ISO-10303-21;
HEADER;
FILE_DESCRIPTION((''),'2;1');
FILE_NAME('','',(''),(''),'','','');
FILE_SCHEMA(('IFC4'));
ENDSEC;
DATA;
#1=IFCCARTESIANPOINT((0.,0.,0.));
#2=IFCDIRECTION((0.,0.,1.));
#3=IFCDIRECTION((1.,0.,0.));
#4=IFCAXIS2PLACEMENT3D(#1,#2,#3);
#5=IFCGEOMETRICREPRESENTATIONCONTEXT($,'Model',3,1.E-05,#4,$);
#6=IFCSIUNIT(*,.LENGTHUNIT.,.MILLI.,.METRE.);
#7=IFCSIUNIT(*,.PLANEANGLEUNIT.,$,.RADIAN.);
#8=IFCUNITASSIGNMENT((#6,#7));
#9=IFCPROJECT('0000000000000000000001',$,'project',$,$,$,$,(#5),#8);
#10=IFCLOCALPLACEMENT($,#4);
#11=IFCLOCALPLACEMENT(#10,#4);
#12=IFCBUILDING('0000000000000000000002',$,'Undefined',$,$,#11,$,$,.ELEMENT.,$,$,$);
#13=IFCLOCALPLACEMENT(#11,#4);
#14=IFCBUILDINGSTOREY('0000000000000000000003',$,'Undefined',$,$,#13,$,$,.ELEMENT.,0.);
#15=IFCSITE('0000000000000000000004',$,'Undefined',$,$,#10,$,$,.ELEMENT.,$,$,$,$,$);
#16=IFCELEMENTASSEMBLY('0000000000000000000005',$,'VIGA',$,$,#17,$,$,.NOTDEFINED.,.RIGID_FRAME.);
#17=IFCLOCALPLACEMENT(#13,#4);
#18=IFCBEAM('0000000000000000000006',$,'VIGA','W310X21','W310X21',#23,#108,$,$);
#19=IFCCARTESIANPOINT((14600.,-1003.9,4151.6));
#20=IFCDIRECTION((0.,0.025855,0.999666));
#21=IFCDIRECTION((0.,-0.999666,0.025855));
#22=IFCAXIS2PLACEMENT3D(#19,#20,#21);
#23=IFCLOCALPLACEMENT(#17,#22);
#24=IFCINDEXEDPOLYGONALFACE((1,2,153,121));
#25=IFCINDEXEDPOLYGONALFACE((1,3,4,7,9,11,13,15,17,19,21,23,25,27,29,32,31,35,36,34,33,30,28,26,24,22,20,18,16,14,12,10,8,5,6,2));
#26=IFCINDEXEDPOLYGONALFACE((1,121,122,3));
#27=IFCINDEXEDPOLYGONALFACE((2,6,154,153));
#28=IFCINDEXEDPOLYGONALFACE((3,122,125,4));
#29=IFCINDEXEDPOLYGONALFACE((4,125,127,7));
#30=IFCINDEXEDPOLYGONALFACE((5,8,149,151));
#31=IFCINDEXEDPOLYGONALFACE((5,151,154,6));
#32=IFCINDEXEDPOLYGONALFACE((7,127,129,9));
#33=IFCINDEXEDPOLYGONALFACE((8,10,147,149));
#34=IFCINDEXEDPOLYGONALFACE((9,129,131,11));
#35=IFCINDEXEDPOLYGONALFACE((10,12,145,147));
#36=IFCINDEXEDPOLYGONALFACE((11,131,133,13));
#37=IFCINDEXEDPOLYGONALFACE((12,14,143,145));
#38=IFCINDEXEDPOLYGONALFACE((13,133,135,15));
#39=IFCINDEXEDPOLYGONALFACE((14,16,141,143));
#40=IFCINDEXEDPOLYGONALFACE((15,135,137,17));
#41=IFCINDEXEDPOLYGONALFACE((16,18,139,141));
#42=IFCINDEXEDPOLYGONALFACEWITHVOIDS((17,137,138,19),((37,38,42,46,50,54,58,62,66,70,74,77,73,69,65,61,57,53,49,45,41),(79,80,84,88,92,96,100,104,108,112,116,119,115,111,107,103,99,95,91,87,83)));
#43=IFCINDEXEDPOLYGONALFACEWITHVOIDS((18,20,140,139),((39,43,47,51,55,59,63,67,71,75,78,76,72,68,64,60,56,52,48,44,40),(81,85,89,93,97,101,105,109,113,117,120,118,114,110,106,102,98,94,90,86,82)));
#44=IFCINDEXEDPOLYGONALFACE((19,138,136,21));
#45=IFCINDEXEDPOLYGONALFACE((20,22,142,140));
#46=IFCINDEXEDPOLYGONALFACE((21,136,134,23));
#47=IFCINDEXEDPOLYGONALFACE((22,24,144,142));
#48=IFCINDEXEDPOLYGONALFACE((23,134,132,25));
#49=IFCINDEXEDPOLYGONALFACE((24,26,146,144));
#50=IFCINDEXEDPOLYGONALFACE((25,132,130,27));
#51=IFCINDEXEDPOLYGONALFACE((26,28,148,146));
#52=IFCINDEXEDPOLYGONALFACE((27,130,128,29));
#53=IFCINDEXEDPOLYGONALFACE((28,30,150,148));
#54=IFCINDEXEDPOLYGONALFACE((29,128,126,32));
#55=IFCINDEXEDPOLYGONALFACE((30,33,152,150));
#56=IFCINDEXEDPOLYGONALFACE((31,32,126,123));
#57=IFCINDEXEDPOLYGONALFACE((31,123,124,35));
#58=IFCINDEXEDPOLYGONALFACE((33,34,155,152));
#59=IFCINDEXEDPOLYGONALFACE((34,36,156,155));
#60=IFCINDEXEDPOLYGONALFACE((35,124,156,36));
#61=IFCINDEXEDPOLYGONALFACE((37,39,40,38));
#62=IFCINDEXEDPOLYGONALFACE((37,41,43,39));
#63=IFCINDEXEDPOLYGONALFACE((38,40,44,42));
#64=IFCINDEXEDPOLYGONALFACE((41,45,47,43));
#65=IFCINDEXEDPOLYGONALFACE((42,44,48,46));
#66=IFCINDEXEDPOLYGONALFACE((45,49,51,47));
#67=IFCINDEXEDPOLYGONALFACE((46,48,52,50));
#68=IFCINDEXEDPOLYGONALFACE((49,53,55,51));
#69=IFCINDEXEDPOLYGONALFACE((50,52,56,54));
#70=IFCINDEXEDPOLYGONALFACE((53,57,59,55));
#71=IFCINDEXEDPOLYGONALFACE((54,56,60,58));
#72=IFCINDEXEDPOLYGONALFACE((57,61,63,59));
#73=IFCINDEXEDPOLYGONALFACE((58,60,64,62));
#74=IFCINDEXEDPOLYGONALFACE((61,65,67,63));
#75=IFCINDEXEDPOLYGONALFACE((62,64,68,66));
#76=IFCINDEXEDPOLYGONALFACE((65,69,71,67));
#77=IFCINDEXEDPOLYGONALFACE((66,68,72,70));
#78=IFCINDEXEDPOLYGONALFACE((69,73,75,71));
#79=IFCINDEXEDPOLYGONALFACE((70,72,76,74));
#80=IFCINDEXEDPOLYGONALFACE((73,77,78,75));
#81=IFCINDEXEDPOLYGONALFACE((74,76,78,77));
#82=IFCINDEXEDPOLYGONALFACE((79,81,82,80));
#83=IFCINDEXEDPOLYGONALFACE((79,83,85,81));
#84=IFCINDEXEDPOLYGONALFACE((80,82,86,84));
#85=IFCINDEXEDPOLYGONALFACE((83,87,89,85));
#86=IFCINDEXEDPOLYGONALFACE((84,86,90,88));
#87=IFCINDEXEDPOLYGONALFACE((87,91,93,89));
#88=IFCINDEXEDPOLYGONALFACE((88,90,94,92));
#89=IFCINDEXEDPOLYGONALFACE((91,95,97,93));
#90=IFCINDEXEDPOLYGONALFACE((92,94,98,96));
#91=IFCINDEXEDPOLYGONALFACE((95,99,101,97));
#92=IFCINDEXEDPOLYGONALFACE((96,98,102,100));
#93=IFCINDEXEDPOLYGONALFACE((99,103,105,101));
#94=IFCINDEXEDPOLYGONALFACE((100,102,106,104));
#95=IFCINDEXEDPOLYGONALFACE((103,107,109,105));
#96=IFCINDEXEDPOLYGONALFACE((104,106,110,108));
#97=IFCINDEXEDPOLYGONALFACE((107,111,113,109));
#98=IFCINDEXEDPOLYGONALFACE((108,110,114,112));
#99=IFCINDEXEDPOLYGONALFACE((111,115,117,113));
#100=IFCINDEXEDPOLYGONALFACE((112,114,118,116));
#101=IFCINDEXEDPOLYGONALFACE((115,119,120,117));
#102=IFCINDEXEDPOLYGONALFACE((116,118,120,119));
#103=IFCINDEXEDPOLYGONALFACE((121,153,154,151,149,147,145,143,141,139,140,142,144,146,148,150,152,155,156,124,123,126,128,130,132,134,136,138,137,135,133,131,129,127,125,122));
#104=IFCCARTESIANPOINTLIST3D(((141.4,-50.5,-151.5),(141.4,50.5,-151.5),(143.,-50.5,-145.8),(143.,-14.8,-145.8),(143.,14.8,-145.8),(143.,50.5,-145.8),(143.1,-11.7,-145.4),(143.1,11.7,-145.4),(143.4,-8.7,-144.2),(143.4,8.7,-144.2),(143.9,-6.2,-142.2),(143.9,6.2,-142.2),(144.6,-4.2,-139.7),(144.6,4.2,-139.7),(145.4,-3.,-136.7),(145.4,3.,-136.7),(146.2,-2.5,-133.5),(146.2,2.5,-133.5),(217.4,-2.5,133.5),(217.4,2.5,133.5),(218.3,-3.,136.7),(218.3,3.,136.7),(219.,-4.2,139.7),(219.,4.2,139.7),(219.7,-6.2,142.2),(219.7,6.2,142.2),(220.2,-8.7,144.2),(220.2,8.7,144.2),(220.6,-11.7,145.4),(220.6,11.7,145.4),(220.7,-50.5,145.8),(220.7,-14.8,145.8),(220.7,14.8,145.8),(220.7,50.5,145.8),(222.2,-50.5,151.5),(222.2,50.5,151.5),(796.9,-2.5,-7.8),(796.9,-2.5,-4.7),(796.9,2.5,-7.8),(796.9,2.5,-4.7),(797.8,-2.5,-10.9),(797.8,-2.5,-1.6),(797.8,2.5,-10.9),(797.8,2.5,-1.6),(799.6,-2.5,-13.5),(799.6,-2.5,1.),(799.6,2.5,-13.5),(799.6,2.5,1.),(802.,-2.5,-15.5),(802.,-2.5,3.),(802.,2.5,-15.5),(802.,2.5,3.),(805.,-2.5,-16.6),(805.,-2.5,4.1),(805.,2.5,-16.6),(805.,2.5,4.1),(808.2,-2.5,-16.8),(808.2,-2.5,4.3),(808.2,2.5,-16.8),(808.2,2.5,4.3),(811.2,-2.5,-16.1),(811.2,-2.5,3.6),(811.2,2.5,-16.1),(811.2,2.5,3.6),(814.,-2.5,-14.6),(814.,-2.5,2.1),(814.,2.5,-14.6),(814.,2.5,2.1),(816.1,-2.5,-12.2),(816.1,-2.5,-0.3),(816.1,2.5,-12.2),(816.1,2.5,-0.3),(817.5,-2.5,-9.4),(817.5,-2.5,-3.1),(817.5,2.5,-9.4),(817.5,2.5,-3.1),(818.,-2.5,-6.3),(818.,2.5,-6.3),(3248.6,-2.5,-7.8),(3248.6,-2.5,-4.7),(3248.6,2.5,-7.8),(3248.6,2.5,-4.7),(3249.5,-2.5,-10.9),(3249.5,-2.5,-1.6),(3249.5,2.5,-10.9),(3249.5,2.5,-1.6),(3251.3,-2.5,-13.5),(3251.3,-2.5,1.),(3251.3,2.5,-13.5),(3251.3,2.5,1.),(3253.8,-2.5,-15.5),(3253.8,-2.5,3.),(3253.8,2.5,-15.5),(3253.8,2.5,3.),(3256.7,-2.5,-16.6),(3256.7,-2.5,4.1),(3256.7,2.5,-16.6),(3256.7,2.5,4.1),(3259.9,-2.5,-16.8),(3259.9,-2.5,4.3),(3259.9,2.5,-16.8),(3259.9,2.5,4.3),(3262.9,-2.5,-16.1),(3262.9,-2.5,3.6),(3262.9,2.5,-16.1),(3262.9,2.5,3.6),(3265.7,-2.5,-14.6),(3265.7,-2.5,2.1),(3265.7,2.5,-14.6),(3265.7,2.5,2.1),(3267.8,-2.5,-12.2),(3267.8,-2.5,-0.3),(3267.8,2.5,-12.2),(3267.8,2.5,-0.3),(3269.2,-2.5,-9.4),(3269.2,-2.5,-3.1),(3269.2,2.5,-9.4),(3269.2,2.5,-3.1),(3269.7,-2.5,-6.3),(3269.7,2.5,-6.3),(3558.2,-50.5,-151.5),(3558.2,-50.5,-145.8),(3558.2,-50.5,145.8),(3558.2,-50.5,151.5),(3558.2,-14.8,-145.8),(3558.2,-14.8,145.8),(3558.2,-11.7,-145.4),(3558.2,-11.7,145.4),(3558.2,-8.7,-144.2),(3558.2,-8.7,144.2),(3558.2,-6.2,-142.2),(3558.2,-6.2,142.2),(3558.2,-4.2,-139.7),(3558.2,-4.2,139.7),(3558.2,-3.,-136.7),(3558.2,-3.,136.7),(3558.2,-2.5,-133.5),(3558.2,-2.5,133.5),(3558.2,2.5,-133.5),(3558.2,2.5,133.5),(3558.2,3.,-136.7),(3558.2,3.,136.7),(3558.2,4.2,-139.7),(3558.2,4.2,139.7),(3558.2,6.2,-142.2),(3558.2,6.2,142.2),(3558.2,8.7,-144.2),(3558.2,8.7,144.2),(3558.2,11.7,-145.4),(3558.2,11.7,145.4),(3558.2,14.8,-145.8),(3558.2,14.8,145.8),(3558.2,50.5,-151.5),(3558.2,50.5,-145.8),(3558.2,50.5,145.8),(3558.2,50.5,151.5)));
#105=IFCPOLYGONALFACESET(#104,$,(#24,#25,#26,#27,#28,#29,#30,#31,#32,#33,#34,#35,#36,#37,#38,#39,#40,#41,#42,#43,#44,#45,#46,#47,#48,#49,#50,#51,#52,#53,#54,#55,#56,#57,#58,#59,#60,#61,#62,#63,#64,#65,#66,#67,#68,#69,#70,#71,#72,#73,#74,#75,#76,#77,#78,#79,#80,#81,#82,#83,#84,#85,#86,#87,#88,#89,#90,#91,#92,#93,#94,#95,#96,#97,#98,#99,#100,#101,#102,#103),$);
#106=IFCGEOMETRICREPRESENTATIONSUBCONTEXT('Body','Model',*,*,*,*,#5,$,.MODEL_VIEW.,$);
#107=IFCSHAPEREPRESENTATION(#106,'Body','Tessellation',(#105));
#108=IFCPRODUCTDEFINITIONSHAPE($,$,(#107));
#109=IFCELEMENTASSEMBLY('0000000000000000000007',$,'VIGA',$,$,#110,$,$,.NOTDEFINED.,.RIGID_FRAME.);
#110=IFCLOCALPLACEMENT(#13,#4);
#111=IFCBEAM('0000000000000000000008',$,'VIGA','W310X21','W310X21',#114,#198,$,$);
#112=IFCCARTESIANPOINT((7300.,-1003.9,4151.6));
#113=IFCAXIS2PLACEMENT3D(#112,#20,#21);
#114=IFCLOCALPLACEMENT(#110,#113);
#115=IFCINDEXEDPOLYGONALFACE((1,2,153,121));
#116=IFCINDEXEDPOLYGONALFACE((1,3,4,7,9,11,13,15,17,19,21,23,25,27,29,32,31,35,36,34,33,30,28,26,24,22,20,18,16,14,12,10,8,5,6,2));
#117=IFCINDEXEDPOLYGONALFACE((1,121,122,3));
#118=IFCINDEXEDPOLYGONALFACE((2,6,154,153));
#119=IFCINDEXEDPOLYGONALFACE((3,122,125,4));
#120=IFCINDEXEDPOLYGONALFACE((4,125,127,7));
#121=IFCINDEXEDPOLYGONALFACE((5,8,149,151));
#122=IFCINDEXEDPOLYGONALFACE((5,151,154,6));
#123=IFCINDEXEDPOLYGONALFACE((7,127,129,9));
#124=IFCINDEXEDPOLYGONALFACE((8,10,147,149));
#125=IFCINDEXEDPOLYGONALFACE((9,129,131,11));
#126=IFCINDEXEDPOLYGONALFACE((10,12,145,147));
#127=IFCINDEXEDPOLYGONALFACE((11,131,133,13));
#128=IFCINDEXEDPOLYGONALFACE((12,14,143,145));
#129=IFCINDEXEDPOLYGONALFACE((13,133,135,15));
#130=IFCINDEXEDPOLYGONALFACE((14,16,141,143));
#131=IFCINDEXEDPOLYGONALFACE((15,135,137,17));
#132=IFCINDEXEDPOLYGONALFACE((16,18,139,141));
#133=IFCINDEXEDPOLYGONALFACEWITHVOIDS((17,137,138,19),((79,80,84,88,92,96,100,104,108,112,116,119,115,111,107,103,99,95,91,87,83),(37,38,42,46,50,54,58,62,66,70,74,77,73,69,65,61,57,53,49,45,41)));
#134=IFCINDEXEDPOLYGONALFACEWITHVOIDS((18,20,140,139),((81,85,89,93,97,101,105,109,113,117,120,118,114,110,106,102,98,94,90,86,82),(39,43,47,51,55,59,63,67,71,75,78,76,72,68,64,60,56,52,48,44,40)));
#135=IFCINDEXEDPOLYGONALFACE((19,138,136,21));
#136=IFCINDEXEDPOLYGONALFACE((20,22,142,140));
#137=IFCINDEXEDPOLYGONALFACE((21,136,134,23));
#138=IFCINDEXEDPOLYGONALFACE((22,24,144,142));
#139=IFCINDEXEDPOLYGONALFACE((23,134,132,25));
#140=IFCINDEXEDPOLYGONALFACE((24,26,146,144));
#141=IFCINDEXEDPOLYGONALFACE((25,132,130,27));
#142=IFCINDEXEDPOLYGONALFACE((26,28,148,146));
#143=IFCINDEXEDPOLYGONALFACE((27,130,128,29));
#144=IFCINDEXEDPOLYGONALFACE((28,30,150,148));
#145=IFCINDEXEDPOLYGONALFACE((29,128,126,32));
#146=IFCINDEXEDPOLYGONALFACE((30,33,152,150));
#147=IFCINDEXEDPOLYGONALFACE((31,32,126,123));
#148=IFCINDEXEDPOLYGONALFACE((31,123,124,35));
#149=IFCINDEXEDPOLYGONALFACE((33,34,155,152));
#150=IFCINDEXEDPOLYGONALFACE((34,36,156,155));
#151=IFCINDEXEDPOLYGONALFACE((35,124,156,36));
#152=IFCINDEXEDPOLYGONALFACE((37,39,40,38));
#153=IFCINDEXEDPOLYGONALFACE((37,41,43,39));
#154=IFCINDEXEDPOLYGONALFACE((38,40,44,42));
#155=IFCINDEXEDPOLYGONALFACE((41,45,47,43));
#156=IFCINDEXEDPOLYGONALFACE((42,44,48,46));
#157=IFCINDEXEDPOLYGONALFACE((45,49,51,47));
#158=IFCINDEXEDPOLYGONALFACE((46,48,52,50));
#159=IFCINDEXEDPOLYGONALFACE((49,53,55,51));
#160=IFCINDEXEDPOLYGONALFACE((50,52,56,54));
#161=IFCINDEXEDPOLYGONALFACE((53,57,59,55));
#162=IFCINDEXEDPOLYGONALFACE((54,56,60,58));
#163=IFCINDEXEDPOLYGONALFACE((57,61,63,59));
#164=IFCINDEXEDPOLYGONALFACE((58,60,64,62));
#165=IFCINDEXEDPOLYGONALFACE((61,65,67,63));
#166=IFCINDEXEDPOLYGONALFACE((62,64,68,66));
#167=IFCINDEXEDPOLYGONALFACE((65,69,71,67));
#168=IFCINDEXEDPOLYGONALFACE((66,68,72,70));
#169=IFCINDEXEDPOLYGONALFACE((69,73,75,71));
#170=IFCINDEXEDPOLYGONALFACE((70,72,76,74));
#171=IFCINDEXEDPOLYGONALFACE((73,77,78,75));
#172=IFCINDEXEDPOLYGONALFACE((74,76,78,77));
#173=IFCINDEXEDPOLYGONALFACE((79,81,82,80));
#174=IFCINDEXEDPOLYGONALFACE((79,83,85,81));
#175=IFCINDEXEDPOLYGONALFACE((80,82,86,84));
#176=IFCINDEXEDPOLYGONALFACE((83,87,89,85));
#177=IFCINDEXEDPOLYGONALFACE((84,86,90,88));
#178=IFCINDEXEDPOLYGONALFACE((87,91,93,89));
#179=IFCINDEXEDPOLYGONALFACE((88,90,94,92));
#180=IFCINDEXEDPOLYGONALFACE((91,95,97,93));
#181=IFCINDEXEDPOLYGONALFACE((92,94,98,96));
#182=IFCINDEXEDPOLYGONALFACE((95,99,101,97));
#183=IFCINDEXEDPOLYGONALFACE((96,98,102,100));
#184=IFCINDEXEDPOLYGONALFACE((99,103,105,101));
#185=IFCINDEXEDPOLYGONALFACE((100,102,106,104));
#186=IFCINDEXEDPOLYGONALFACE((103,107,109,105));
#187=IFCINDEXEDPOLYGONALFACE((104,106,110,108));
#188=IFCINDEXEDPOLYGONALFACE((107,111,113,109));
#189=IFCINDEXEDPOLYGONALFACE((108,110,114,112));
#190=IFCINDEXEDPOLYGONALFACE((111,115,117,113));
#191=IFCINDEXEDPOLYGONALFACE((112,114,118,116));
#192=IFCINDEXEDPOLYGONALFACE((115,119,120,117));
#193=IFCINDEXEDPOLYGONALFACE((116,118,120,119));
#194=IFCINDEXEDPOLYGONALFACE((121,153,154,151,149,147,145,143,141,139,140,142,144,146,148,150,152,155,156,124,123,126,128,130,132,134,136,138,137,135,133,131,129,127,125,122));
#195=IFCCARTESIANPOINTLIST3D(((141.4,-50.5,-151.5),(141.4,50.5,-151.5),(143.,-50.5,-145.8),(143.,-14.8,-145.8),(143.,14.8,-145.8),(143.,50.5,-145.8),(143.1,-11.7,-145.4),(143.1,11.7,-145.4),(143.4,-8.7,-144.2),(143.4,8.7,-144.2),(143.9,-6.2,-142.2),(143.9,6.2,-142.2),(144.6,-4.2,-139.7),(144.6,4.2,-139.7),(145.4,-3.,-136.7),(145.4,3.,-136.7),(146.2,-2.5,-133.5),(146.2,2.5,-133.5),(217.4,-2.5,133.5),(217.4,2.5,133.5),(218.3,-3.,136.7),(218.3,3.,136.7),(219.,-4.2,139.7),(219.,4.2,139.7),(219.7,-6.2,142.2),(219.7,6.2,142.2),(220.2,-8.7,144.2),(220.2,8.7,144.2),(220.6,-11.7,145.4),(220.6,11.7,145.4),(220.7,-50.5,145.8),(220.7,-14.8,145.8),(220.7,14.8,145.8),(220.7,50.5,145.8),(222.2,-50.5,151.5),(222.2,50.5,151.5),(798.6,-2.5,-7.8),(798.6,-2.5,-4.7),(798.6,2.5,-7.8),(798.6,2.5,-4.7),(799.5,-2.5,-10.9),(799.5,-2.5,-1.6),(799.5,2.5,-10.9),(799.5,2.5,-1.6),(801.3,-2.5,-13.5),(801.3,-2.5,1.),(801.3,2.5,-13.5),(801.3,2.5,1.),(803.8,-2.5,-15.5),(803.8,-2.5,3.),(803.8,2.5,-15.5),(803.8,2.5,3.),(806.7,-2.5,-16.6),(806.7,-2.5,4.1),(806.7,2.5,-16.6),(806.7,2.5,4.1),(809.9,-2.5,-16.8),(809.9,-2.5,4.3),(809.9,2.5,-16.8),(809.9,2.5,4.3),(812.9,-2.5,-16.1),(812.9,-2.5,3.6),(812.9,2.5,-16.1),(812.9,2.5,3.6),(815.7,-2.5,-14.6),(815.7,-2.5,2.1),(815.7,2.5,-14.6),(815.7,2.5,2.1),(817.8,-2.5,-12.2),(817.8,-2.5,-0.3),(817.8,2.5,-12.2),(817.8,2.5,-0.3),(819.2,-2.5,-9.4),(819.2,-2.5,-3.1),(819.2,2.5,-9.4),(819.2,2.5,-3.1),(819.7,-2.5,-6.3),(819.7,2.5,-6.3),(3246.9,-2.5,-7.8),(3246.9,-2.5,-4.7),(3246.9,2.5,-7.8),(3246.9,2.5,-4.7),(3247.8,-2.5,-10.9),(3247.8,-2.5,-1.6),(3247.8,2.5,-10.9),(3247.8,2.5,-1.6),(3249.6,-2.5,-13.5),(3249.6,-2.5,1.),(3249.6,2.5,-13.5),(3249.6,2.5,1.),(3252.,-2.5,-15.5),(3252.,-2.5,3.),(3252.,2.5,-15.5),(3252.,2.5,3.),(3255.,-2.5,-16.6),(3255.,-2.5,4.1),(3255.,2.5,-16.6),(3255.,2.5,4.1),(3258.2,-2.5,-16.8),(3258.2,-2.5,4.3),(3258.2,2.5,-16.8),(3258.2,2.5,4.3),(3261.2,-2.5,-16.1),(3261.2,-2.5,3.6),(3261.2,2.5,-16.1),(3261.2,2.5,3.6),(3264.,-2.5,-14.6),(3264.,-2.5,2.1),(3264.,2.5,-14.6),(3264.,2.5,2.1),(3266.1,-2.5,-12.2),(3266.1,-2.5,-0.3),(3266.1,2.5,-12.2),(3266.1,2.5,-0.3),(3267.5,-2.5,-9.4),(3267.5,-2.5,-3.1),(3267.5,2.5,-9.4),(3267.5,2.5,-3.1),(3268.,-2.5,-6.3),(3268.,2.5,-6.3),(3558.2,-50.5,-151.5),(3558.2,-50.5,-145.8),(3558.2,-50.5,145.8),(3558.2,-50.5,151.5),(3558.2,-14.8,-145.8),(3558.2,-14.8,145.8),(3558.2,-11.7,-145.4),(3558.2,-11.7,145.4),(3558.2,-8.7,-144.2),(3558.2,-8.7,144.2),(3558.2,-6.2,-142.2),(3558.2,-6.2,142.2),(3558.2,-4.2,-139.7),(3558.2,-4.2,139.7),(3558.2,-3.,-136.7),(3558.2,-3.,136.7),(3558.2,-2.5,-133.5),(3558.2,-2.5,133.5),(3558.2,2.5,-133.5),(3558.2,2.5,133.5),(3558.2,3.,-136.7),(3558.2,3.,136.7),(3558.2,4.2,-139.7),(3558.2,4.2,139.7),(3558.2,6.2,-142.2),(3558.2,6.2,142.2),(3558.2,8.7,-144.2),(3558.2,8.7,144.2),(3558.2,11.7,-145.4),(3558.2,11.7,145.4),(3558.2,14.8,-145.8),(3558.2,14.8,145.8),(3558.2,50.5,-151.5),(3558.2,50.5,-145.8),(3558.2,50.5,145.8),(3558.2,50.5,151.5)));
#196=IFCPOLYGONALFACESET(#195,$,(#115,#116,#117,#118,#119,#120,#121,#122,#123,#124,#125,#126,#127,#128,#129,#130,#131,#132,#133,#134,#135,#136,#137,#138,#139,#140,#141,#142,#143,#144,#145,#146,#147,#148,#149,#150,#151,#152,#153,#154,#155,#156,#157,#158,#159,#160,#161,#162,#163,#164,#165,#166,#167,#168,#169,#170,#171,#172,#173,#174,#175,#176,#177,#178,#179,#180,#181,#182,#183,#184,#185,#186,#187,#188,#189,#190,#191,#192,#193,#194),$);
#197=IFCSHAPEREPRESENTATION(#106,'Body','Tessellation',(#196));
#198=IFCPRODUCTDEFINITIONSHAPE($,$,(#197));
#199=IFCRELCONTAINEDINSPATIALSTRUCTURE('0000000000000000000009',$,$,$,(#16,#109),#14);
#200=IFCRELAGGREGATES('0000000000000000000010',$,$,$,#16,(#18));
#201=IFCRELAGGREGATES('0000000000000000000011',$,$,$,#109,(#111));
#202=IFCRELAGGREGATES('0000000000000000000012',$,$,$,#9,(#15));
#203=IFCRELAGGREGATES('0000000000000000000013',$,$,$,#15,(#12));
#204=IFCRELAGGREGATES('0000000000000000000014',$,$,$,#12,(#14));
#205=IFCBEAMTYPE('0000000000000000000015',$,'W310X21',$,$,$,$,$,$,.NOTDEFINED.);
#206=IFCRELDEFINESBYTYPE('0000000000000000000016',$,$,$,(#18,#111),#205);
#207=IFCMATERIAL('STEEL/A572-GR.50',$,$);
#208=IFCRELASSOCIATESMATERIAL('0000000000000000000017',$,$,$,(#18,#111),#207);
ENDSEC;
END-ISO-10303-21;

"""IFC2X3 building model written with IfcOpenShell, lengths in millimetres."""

from ifc_helpers import new_model, si_unit, frame, origin_with_axes, origin_2d_with_axis, place, context, subcontext, project, spatial, circle, i_section, extrude, boolean, halfspace, material, type_object, element, aggregate, save


model = new_model("IFC2X3")

# Units and contexts
model_context = context("Model", 3, precision=1e-05, world=origin_with_axes())
body_context = subcontext(model_context, "Body", "Model", "MODEL_VIEW")
ifc_project = project(units=[si_unit("LENGTHUNIT", "METRE", prefix="MILLI"), si_unit("PLANEANGLEUNIT", "RADIAN")], contexts=[model_context])

# Site, building, storey
site_placement = place(None, origin_with_axes())
site = spatial("IfcSite", under=ifc_project, at=site_placement, Name="Undefined", CompositionType="ELEMENT")
building_placement = place(site_placement, origin_with_axes())
building = spatial("IfcBuilding", under=site, at=building_placement, Name="Undefined", CompositionType="ELEMENT")
storey_placement = place(building_placement, origin_with_axes())
storey = spatial("IfcBuildingStorey", under=building, at=storey_placement, Name="Undefined", CompositionType="ELEMENT", Elevation=0.0)

# Element assemblies, beams
ifc_material_1 = material(Name="STEEL/A572-GR.50")
assembly_1_placement = place(storey_placement, origin_with_axes())
assembly_1 = element("IfcElementAssembly", 1, at=assembly_1_placement, inside=storey, Name="VIGA", AssemblyPlace="NOTDEFINED", PredefinedType="RIGID_FRAME")
beam_type_1 = type_object("IfcBeamType", Name="W310X21", PredefinedType="NOTDEFINED")
beam_1_placement = place(assembly_1_placement, frame((14600.0, -1003.9, 4151.6), z_axis=(0.0, 0.025855, 0.999666), x_axis=(0.0, -0.999666, 0.025855)))
beam_1 = element("IfcBeam", 2, at=beam_1_placement, type_object=beam_type_1, material=ifc_material_1, Name="VIGA", Description="W310X21", ObjectType="W310X21", context=body_context, shape_type="CSG", body=[
    boolean("DIFFERENCE", boolean("DIFFERENCE", boolean("DIFFERENCE", extrude(i_section(OverallWidth=101.0, OverallDepth=303.0, WebThickness=5.1, FlangeThickness=5.7, FilletRadius=12.3, at=origin_2d_with_axis()), frame((3558.2, 0.0, 0.0), z_axis=(-1.0, 0.0, 0.0), x_axis=(0.0, -1.0, 0.0)), (0.0, 0.0, 1.0), 3558.2), extrude(circle(Radius=10.6, at=origin_2d_with_axis()), frame((3259.1, 100.0, -6.3), z_axis=(0.0, -1.0, 0.0), x_axis=(1.0, 0.0, 0.0)), (0.0, 0.0, 1.0), 200.0)), extrude(circle(Radius=10.6, at=origin_2d_with_axis()), frame((807.4, 100.0, -6.3), z_axis=(0.0, -1.0, 0.0), x_axis=(1.0, 0.0, 0.0)), (0.0, 0.0, 1.0), 200.0)), halfspace(frame((141.4, 50.5, -151.7), z_axis=(-0.966259, 0.0, 0.257573), x_axis=(0.257573, 0.0, 0.966259)), False)),
])
aggregate(assembly_1, [beam_1])
assembly_2_placement = place(storey_placement, origin_with_axes())
assembly_2 = element("IfcElementAssembly", 3, at=assembly_2_placement, inside=storey, Name="VIGA", AssemblyPlace="NOTDEFINED", PredefinedType="RIGID_FRAME")
beam_2_placement = place(assembly_2_placement, frame((7300.0, -1003.9, 4151.6), z_axis=(0.0, 0.025855, 0.999666), x_axis=(0.0, -0.999666, 0.025855)))
beam_2 = element("IfcBeam", 4, at=beam_2_placement, type_object=beam_type_1, material=ifc_material_1, Name="VIGA", Description="W310X21", ObjectType="W310X21", context=body_context, shape_type="CSG", body=[
    boolean("DIFFERENCE", boolean("DIFFERENCE", boolean("DIFFERENCE", extrude(i_section(OverallWidth=101.0, OverallDepth=303.0, WebThickness=5.1, FlangeThickness=5.7, FilletRadius=12.3, at=origin_2d_with_axis()), frame((3558.2, 0.0, 0.0), z_axis=(-1.0, 0.0, 0.0), x_axis=(0.0, -1.0, 0.0)), (0.0, 0.0, 1.0), 3558.2), extrude(circle(Radius=10.6, at=origin_2d_with_axis()), frame((3257.4, -100.0, -6.3), z_axis=(0.0, 1.0, 0.0), x_axis=(1.0, 0.0, 0.0)), (0.0, 0.0, 1.0), 200.0)), extrude(circle(Radius=10.6, at=origin_2d_with_axis()), frame((809.1, -100.0, -6.3), z_axis=(0.0, 1.0, 0.0), x_axis=(1.0, 0.0, 0.0)), (0.0, 0.0, 1.0), 200.0)), halfspace(frame((141.4, 50.5, -151.7), z_axis=(-0.966259, 0.0, 0.257573), x_axis=(0.257573, 0.0, 0.966259)), False)),
])
aggregate(assembly_2, [beam_2])

save(model, "model.ifc")
